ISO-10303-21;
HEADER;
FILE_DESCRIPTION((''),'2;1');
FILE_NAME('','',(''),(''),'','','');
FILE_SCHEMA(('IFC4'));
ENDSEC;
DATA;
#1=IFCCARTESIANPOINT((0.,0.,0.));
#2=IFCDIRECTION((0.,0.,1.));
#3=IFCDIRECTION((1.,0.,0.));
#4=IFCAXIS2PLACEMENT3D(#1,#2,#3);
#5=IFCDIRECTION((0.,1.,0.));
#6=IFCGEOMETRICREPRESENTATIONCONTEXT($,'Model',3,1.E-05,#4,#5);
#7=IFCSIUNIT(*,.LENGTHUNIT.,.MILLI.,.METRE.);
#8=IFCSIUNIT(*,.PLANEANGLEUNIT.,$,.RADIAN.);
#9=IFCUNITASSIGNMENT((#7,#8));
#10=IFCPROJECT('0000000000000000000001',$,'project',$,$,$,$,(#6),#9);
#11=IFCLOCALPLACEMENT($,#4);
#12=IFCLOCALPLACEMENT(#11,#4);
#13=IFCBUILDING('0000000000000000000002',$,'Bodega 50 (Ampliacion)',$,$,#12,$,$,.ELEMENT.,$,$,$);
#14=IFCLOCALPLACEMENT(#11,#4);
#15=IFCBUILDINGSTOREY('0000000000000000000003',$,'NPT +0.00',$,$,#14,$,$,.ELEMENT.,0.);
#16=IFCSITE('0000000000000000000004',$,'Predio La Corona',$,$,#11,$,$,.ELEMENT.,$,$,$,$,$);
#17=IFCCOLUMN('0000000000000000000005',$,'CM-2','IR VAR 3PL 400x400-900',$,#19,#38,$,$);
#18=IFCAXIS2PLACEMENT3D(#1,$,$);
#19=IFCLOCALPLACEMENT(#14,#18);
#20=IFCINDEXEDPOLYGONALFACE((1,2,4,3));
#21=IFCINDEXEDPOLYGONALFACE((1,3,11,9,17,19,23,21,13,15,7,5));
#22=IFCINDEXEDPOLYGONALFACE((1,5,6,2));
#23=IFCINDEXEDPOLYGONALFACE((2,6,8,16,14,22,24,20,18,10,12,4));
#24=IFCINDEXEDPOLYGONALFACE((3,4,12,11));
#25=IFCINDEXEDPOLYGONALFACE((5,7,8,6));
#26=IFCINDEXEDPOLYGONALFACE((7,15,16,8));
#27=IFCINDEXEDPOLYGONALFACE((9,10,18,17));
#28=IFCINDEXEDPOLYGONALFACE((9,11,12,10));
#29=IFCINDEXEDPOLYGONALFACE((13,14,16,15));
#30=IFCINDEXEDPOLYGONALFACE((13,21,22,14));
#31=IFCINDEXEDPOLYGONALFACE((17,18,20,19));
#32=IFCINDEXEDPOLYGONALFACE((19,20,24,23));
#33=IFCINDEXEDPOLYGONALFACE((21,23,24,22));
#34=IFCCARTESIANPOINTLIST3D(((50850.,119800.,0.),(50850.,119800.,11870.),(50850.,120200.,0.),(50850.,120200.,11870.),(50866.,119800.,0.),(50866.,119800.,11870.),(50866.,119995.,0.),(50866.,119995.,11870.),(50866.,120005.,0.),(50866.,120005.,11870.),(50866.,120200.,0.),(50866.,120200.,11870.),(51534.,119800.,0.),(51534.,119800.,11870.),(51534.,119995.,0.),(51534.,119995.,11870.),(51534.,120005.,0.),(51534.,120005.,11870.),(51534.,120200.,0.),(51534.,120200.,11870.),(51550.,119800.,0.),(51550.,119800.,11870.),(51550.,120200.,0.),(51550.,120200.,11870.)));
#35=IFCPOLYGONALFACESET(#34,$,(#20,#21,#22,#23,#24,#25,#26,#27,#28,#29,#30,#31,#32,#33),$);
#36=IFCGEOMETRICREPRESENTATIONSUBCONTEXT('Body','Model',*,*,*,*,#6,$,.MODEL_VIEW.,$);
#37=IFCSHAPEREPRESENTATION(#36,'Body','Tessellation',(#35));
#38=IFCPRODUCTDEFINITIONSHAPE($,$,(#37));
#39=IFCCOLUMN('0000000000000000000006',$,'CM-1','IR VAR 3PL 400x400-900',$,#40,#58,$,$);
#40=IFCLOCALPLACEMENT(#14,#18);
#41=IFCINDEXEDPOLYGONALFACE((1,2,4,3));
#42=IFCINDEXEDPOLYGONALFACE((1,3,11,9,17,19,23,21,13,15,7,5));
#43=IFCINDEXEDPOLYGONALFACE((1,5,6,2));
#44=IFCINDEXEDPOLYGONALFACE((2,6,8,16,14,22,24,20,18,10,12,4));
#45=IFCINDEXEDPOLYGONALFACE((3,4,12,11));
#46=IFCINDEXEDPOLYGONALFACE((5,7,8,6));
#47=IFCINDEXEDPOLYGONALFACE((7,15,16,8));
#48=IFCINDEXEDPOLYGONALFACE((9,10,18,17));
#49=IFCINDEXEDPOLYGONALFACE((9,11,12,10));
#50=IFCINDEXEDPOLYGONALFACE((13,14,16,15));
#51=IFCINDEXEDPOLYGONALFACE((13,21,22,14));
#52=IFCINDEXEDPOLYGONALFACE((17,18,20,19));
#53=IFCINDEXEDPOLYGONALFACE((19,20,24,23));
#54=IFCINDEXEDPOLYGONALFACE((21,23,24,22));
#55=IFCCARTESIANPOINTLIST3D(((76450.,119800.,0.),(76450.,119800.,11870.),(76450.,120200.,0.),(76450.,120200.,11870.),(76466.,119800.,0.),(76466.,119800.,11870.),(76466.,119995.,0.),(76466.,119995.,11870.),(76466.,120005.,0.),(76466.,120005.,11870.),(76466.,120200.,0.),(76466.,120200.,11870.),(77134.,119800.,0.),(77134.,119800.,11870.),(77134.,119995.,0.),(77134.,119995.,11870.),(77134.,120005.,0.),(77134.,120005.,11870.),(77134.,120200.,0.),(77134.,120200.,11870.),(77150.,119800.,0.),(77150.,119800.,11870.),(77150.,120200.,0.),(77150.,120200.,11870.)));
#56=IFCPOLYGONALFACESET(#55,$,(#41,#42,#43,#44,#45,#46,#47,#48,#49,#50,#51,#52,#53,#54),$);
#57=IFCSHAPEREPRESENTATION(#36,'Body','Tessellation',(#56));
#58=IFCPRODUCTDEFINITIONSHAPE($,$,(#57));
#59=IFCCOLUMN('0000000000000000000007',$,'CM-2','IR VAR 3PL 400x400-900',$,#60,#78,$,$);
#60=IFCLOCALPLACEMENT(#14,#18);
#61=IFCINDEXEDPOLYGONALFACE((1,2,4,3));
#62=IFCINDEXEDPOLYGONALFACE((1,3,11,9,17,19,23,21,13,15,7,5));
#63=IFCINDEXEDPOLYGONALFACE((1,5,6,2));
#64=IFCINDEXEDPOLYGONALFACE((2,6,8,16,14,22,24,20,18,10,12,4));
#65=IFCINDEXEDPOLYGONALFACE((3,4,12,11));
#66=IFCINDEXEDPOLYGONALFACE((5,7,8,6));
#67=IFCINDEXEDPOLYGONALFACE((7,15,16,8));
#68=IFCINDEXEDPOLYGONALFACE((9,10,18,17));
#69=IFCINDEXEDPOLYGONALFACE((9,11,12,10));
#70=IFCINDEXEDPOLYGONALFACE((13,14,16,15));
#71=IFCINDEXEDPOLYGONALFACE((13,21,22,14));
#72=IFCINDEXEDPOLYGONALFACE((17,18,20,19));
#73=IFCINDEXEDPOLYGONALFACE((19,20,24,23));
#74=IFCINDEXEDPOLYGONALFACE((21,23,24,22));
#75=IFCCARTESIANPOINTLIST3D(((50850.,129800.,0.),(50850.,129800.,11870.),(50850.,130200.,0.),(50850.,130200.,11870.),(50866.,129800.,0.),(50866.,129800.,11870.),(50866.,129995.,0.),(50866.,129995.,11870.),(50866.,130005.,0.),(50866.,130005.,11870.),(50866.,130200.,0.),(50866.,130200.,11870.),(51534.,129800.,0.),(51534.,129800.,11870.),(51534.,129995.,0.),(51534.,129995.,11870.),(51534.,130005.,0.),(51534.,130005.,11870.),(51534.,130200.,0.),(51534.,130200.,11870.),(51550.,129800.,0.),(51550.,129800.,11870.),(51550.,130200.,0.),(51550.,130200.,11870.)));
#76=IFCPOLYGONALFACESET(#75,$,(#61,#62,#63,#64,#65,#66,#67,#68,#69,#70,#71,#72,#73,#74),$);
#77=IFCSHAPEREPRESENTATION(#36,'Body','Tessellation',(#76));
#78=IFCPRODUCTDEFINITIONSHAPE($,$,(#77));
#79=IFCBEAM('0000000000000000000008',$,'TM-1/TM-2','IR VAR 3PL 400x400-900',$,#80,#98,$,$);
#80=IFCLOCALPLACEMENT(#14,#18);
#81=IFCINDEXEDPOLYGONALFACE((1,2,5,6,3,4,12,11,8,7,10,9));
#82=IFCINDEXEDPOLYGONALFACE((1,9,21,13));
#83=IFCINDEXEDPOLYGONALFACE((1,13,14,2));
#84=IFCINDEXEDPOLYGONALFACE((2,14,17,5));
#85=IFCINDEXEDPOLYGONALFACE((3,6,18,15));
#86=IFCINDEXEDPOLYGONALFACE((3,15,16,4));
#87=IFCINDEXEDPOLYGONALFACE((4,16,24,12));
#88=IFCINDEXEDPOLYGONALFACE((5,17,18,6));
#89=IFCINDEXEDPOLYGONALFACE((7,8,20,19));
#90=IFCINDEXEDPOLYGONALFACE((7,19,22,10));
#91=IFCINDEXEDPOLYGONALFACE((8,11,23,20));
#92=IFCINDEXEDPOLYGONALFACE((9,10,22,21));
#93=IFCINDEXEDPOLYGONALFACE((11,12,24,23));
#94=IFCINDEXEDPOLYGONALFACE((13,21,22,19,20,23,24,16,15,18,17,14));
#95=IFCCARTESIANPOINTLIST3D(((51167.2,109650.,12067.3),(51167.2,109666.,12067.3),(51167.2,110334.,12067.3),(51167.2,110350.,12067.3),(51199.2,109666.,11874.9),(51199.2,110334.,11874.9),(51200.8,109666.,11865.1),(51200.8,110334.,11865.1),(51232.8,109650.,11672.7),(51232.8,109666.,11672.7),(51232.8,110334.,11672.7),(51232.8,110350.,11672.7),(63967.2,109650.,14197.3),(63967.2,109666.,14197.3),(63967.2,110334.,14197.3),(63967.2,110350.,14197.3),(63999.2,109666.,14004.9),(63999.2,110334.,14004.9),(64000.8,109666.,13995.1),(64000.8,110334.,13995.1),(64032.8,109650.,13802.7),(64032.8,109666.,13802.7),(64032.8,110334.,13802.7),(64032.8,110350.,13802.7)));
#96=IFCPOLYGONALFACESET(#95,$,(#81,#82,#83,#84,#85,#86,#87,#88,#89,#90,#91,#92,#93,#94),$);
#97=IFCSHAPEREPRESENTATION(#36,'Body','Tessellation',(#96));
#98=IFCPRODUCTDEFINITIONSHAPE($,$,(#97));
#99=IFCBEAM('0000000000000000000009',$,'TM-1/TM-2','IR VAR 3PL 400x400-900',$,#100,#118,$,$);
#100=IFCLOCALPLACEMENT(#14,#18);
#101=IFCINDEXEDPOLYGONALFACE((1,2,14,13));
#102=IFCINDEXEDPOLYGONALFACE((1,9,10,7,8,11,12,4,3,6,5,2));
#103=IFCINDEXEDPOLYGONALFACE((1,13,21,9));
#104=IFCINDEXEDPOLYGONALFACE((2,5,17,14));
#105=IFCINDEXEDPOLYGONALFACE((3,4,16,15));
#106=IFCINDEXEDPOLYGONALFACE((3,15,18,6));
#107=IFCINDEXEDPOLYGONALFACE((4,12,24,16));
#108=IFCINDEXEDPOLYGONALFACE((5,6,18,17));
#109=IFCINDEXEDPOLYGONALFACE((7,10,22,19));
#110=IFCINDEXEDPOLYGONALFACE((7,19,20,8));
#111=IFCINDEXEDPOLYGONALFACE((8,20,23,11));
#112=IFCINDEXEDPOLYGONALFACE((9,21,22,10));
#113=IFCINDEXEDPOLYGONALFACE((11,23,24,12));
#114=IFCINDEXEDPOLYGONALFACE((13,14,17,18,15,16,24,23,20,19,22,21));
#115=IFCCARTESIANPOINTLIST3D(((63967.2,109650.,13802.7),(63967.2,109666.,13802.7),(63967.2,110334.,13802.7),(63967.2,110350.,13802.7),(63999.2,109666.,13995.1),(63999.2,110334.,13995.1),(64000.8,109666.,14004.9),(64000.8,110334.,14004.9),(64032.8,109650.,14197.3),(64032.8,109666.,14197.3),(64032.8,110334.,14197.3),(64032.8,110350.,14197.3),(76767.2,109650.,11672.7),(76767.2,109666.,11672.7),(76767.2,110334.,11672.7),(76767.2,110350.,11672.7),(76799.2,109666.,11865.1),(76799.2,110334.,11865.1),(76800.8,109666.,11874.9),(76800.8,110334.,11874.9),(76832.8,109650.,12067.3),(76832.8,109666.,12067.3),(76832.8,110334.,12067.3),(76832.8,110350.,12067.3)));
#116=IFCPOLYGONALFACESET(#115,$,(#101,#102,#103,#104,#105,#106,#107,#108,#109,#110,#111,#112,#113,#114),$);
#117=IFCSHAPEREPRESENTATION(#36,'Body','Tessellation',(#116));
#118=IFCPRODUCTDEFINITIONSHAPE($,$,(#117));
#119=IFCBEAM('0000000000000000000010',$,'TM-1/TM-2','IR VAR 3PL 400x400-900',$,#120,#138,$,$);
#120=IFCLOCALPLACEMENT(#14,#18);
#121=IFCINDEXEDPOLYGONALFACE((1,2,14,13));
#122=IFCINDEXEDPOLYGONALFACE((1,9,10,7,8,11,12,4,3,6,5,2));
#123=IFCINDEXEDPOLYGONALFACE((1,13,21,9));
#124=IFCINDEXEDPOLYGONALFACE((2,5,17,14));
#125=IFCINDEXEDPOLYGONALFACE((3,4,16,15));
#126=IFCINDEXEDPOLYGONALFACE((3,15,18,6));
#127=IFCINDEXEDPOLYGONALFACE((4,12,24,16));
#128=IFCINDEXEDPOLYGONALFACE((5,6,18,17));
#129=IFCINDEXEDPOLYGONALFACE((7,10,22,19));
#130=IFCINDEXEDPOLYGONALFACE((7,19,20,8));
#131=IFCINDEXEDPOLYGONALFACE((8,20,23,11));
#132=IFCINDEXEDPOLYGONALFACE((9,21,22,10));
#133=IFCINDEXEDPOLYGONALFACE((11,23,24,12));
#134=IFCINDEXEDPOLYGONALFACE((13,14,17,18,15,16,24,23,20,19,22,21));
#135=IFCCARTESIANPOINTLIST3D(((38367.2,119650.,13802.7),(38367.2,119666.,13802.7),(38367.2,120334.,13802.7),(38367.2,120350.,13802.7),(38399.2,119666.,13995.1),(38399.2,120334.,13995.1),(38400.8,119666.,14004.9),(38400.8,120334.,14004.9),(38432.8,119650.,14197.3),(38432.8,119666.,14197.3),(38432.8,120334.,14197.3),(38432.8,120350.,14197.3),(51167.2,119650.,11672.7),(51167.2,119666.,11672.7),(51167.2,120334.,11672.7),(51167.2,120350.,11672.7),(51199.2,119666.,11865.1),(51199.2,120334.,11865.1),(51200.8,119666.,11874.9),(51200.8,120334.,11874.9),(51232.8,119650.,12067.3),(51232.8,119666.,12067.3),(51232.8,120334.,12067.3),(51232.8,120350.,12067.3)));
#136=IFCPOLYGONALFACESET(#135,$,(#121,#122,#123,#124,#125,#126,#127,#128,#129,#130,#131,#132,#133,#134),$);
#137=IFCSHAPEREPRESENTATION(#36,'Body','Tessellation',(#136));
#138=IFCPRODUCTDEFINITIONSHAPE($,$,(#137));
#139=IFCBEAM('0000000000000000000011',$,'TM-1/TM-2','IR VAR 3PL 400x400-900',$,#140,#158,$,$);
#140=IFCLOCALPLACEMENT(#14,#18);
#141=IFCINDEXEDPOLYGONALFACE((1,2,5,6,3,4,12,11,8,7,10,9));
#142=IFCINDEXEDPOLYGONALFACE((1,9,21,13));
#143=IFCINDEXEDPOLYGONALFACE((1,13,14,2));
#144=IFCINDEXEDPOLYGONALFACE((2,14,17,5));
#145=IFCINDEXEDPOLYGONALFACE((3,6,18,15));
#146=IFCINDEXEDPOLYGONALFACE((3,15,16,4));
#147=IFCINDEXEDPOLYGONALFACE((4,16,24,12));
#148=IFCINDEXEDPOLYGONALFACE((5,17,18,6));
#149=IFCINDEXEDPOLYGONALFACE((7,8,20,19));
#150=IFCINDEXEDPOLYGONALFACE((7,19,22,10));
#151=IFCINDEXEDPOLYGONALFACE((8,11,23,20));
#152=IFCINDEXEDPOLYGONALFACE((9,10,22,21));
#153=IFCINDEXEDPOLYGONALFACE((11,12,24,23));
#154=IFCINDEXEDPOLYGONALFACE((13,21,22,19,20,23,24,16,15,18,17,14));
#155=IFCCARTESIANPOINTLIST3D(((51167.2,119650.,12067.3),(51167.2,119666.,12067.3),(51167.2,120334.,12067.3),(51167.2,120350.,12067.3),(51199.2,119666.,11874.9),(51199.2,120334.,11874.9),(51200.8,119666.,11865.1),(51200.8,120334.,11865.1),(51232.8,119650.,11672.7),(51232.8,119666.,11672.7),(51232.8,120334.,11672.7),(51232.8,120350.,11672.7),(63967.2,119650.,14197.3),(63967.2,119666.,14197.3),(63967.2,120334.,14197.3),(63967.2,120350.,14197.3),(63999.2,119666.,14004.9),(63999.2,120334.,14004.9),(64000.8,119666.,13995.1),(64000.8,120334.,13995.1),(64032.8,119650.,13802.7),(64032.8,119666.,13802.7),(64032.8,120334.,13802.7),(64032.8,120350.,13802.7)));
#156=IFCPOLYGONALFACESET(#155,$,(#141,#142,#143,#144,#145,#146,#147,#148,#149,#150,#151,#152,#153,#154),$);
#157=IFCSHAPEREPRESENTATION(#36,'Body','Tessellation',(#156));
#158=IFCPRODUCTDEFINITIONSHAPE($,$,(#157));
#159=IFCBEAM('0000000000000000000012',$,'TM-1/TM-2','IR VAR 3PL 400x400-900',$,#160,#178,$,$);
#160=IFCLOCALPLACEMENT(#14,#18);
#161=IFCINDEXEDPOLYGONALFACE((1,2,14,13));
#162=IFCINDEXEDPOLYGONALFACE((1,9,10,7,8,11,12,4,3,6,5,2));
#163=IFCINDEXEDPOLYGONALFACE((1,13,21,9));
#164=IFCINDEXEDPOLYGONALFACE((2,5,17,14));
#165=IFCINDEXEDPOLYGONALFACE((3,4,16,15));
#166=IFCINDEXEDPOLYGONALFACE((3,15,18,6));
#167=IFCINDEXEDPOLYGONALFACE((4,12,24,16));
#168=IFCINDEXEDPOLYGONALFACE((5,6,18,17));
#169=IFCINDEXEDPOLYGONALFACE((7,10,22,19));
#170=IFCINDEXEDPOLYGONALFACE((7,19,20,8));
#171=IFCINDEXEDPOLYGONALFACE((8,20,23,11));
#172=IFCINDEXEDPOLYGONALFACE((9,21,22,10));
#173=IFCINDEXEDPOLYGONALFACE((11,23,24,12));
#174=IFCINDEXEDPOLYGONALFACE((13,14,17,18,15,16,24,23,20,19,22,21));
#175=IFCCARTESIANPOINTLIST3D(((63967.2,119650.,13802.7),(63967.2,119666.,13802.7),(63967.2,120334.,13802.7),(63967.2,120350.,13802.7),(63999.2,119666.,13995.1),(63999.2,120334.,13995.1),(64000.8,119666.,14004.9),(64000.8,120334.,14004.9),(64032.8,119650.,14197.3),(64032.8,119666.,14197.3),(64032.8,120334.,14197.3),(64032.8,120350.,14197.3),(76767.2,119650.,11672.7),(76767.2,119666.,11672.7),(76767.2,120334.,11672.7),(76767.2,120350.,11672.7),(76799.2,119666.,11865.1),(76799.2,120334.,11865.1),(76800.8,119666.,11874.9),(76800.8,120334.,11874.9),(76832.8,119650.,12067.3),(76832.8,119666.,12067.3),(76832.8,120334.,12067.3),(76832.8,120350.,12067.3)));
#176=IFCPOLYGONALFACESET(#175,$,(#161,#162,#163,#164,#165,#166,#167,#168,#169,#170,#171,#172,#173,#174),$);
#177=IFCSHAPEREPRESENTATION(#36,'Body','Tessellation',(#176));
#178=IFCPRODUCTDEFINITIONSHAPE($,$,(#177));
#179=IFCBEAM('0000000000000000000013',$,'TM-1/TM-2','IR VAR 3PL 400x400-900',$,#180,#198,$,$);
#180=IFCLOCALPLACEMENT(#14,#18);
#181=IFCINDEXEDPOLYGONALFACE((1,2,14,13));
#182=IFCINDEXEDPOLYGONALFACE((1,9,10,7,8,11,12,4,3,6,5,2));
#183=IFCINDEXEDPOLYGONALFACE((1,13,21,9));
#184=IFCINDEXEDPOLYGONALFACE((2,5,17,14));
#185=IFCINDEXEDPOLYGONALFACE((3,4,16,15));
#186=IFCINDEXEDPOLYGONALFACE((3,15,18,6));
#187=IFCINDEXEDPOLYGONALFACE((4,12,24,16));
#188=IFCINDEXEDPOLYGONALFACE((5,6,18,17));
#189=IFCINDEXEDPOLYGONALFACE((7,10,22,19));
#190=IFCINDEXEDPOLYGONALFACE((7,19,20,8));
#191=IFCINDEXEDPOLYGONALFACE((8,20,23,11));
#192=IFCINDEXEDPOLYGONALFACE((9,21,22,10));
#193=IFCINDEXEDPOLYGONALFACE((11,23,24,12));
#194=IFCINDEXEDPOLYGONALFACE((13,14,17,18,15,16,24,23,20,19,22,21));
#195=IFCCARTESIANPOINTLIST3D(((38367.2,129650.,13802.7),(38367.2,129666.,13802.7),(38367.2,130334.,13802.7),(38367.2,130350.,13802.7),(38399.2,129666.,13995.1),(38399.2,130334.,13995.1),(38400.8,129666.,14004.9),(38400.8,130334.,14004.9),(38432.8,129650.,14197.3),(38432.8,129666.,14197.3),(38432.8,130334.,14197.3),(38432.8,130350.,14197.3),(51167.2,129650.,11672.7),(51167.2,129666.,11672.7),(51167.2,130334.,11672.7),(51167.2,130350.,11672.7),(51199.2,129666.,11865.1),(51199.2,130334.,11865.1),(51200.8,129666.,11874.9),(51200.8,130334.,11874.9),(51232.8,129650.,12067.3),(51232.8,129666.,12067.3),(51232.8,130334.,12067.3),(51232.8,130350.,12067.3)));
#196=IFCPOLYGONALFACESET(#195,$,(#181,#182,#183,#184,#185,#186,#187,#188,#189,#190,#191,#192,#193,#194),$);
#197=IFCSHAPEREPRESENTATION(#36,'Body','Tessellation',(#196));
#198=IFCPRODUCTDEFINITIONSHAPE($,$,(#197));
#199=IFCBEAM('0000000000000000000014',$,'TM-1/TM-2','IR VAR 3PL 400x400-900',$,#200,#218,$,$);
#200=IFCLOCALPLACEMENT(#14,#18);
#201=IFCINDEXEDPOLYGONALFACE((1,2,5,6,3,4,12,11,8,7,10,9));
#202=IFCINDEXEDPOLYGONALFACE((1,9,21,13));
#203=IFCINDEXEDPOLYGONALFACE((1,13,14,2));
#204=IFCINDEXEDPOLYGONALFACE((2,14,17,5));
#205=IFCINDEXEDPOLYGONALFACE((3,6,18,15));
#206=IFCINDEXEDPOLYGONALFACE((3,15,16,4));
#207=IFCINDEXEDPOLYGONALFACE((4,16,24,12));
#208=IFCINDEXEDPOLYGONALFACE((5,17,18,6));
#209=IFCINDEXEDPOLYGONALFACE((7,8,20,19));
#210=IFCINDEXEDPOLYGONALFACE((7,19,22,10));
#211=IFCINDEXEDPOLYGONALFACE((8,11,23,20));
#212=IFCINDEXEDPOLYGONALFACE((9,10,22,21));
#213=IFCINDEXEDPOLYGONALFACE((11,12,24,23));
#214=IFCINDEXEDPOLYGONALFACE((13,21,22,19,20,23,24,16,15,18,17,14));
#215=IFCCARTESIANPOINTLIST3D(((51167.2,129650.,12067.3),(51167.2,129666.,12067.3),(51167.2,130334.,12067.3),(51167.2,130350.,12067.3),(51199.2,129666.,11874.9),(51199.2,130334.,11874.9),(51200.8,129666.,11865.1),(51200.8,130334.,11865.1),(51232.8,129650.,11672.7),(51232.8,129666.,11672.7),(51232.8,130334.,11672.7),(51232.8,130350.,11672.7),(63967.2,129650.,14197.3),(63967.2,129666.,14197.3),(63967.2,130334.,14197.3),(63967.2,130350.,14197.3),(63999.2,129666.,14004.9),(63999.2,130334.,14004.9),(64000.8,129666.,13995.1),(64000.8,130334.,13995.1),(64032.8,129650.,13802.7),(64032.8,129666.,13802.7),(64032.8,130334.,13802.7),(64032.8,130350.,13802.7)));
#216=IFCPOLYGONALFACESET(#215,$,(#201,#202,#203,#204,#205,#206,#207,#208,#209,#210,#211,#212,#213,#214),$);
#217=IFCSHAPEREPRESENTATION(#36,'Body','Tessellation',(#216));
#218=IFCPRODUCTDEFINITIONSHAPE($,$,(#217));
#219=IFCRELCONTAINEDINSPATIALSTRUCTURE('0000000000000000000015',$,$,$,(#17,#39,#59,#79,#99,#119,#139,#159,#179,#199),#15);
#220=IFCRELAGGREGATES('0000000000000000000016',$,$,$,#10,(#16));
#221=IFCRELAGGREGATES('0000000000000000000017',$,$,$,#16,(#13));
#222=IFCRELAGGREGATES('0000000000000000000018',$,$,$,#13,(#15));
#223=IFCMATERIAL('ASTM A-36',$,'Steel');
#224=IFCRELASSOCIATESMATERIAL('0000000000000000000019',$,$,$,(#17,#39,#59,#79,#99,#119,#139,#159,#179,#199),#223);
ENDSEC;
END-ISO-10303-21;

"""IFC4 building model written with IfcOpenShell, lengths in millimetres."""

from ifc_helpers import new_model, si_unit, direction, frame, origin_with_axes, origin_2d, place, context, subcontext, project, spatial, i_section, extrude, material, element, save


model = new_model("IFC4")

# Units and contexts
model_context = context("Model", 3, precision=1e-05, world=origin_with_axes(), true_north=direction((0.0, 1.0, 0.0)))
body_context = subcontext(model_context, "Body", "Model", "MODEL_VIEW")
ifc_project = project(units=[si_unit("LENGTHUNIT", "METRE", prefix="MILLI"), si_unit("PLANEANGLEUNIT", "RADIAN")], contexts=[model_context])

# Site, building, storey
site_placement = place(None, origin_with_axes())
site = spatial("IfcSite", under=ifc_project, at=site_placement, Name="Predio La Corona", CompositionType="ELEMENT")
building_placement = place(site_placement, origin_with_axes())
building = spatial("IfcBuilding", under=site, at=building_placement, Name="Bodega 50 (Ampliacion)", CompositionType="ELEMENT")
storey_placement = place(site_placement, origin_with_axes())
storey = spatial("IfcBuildingStorey", under=building, at=storey_placement, Name="NPT +0.00", CompositionType="ELEMENT", Elevation=0.0)

# Columns
ifc_material = material(Name="ASTM A-36", Category="Steel")
for number, where, z_axis, x_axis, name in (
    (1, (51200.0, 120000.0, 0.0), (0.0, 0.0, 1.0), (0.0, -1.0, 0.0), "CM-2"),
    (2, (76800.0, 120000.0, 0.0), (0.0, 0.0, 1.0), (0.0, -1.0, 0.0), "CM-1"),
    (3, (51200.0, 130000.0, 0.0), (0.0, 0.0, 1.0), (0.0, -1.0, 0.0), "CM-2"),
):
    element("IfcColumn", number, at=place(storey_placement, frame(where, z_axis=z_axis, x_axis=x_axis)), inside=storey, material=ifc_material, Name=name, Description="IR VAR 3PL 400x400-900", context=body_context, shape_type="SweptSolid", body=[
        extrude(i_section(OverallWidth=400.0, OverallDepth=700.0, WebThickness=10.0, FlangeThickness=16.0, at=origin_2d()), origin_with_axes(), (0.0, 0.0, 1.0), 11870.0),
    ])

# Beams
for number, where, z_axis, x_axis, name in (
    (4, (51200.0, 110000.0, 11870.0), (0.986436, 0.0, 0.164149), (0.164149, 0.0, -0.986436), "TM-1/TM-2"),
    (5, (64000.0, 110000.0, 14000.0), (0.986436, 0.0, -0.164149), (-0.164149, 0.0, -0.986436), "TM-1/TM-2"),
    (6, (38400.0, 120000.0, 14000.0), (0.986436, 0.0, -0.164149), (-0.164149, 0.0, -0.986436), "TM-1/TM-2"),
    (7, (51200.0, 120000.0, 11870.0), (0.986436, 0.0, 0.164149), (0.164149, 0.0, -0.986436), "TM-1/TM-2"),
    (8, (64000.0, 120000.0, 14000.0), (0.986436, 0.0, -0.164149), (-0.164149, 0.0, -0.986436), "TM-1/TM-2"),
    (9, (38400.0, 130000.0, 14000.0), (0.986436, 0.0, -0.164149), (-0.164149, 0.0, -0.986436), "TM-1/TM-2"),
    (10, (51200.0, 130000.0, 11870.0), (0.986436, 0.0, 0.164149), (0.164149, 0.0, -0.986436), "TM-1/TM-2"),
):
    element("IfcBeam", number, at=place(storey_placement, frame(where, z_axis=z_axis, x_axis=x_axis)), inside=storey, material=ifc_material, Name=name, Description="IR VAR 3PL 400x400-900", context=body_context, shape_type="SweptSolid", body=[
        extrude(i_section(OverallWidth=400.0, OverallDepth=700.0, WebThickness=10.0, FlangeThickness=16.0, at=origin_2d()), origin_with_axes(), (0.0, 0.0, 1.0), 12976.0),
    ])

save(model, "model.ifc")
